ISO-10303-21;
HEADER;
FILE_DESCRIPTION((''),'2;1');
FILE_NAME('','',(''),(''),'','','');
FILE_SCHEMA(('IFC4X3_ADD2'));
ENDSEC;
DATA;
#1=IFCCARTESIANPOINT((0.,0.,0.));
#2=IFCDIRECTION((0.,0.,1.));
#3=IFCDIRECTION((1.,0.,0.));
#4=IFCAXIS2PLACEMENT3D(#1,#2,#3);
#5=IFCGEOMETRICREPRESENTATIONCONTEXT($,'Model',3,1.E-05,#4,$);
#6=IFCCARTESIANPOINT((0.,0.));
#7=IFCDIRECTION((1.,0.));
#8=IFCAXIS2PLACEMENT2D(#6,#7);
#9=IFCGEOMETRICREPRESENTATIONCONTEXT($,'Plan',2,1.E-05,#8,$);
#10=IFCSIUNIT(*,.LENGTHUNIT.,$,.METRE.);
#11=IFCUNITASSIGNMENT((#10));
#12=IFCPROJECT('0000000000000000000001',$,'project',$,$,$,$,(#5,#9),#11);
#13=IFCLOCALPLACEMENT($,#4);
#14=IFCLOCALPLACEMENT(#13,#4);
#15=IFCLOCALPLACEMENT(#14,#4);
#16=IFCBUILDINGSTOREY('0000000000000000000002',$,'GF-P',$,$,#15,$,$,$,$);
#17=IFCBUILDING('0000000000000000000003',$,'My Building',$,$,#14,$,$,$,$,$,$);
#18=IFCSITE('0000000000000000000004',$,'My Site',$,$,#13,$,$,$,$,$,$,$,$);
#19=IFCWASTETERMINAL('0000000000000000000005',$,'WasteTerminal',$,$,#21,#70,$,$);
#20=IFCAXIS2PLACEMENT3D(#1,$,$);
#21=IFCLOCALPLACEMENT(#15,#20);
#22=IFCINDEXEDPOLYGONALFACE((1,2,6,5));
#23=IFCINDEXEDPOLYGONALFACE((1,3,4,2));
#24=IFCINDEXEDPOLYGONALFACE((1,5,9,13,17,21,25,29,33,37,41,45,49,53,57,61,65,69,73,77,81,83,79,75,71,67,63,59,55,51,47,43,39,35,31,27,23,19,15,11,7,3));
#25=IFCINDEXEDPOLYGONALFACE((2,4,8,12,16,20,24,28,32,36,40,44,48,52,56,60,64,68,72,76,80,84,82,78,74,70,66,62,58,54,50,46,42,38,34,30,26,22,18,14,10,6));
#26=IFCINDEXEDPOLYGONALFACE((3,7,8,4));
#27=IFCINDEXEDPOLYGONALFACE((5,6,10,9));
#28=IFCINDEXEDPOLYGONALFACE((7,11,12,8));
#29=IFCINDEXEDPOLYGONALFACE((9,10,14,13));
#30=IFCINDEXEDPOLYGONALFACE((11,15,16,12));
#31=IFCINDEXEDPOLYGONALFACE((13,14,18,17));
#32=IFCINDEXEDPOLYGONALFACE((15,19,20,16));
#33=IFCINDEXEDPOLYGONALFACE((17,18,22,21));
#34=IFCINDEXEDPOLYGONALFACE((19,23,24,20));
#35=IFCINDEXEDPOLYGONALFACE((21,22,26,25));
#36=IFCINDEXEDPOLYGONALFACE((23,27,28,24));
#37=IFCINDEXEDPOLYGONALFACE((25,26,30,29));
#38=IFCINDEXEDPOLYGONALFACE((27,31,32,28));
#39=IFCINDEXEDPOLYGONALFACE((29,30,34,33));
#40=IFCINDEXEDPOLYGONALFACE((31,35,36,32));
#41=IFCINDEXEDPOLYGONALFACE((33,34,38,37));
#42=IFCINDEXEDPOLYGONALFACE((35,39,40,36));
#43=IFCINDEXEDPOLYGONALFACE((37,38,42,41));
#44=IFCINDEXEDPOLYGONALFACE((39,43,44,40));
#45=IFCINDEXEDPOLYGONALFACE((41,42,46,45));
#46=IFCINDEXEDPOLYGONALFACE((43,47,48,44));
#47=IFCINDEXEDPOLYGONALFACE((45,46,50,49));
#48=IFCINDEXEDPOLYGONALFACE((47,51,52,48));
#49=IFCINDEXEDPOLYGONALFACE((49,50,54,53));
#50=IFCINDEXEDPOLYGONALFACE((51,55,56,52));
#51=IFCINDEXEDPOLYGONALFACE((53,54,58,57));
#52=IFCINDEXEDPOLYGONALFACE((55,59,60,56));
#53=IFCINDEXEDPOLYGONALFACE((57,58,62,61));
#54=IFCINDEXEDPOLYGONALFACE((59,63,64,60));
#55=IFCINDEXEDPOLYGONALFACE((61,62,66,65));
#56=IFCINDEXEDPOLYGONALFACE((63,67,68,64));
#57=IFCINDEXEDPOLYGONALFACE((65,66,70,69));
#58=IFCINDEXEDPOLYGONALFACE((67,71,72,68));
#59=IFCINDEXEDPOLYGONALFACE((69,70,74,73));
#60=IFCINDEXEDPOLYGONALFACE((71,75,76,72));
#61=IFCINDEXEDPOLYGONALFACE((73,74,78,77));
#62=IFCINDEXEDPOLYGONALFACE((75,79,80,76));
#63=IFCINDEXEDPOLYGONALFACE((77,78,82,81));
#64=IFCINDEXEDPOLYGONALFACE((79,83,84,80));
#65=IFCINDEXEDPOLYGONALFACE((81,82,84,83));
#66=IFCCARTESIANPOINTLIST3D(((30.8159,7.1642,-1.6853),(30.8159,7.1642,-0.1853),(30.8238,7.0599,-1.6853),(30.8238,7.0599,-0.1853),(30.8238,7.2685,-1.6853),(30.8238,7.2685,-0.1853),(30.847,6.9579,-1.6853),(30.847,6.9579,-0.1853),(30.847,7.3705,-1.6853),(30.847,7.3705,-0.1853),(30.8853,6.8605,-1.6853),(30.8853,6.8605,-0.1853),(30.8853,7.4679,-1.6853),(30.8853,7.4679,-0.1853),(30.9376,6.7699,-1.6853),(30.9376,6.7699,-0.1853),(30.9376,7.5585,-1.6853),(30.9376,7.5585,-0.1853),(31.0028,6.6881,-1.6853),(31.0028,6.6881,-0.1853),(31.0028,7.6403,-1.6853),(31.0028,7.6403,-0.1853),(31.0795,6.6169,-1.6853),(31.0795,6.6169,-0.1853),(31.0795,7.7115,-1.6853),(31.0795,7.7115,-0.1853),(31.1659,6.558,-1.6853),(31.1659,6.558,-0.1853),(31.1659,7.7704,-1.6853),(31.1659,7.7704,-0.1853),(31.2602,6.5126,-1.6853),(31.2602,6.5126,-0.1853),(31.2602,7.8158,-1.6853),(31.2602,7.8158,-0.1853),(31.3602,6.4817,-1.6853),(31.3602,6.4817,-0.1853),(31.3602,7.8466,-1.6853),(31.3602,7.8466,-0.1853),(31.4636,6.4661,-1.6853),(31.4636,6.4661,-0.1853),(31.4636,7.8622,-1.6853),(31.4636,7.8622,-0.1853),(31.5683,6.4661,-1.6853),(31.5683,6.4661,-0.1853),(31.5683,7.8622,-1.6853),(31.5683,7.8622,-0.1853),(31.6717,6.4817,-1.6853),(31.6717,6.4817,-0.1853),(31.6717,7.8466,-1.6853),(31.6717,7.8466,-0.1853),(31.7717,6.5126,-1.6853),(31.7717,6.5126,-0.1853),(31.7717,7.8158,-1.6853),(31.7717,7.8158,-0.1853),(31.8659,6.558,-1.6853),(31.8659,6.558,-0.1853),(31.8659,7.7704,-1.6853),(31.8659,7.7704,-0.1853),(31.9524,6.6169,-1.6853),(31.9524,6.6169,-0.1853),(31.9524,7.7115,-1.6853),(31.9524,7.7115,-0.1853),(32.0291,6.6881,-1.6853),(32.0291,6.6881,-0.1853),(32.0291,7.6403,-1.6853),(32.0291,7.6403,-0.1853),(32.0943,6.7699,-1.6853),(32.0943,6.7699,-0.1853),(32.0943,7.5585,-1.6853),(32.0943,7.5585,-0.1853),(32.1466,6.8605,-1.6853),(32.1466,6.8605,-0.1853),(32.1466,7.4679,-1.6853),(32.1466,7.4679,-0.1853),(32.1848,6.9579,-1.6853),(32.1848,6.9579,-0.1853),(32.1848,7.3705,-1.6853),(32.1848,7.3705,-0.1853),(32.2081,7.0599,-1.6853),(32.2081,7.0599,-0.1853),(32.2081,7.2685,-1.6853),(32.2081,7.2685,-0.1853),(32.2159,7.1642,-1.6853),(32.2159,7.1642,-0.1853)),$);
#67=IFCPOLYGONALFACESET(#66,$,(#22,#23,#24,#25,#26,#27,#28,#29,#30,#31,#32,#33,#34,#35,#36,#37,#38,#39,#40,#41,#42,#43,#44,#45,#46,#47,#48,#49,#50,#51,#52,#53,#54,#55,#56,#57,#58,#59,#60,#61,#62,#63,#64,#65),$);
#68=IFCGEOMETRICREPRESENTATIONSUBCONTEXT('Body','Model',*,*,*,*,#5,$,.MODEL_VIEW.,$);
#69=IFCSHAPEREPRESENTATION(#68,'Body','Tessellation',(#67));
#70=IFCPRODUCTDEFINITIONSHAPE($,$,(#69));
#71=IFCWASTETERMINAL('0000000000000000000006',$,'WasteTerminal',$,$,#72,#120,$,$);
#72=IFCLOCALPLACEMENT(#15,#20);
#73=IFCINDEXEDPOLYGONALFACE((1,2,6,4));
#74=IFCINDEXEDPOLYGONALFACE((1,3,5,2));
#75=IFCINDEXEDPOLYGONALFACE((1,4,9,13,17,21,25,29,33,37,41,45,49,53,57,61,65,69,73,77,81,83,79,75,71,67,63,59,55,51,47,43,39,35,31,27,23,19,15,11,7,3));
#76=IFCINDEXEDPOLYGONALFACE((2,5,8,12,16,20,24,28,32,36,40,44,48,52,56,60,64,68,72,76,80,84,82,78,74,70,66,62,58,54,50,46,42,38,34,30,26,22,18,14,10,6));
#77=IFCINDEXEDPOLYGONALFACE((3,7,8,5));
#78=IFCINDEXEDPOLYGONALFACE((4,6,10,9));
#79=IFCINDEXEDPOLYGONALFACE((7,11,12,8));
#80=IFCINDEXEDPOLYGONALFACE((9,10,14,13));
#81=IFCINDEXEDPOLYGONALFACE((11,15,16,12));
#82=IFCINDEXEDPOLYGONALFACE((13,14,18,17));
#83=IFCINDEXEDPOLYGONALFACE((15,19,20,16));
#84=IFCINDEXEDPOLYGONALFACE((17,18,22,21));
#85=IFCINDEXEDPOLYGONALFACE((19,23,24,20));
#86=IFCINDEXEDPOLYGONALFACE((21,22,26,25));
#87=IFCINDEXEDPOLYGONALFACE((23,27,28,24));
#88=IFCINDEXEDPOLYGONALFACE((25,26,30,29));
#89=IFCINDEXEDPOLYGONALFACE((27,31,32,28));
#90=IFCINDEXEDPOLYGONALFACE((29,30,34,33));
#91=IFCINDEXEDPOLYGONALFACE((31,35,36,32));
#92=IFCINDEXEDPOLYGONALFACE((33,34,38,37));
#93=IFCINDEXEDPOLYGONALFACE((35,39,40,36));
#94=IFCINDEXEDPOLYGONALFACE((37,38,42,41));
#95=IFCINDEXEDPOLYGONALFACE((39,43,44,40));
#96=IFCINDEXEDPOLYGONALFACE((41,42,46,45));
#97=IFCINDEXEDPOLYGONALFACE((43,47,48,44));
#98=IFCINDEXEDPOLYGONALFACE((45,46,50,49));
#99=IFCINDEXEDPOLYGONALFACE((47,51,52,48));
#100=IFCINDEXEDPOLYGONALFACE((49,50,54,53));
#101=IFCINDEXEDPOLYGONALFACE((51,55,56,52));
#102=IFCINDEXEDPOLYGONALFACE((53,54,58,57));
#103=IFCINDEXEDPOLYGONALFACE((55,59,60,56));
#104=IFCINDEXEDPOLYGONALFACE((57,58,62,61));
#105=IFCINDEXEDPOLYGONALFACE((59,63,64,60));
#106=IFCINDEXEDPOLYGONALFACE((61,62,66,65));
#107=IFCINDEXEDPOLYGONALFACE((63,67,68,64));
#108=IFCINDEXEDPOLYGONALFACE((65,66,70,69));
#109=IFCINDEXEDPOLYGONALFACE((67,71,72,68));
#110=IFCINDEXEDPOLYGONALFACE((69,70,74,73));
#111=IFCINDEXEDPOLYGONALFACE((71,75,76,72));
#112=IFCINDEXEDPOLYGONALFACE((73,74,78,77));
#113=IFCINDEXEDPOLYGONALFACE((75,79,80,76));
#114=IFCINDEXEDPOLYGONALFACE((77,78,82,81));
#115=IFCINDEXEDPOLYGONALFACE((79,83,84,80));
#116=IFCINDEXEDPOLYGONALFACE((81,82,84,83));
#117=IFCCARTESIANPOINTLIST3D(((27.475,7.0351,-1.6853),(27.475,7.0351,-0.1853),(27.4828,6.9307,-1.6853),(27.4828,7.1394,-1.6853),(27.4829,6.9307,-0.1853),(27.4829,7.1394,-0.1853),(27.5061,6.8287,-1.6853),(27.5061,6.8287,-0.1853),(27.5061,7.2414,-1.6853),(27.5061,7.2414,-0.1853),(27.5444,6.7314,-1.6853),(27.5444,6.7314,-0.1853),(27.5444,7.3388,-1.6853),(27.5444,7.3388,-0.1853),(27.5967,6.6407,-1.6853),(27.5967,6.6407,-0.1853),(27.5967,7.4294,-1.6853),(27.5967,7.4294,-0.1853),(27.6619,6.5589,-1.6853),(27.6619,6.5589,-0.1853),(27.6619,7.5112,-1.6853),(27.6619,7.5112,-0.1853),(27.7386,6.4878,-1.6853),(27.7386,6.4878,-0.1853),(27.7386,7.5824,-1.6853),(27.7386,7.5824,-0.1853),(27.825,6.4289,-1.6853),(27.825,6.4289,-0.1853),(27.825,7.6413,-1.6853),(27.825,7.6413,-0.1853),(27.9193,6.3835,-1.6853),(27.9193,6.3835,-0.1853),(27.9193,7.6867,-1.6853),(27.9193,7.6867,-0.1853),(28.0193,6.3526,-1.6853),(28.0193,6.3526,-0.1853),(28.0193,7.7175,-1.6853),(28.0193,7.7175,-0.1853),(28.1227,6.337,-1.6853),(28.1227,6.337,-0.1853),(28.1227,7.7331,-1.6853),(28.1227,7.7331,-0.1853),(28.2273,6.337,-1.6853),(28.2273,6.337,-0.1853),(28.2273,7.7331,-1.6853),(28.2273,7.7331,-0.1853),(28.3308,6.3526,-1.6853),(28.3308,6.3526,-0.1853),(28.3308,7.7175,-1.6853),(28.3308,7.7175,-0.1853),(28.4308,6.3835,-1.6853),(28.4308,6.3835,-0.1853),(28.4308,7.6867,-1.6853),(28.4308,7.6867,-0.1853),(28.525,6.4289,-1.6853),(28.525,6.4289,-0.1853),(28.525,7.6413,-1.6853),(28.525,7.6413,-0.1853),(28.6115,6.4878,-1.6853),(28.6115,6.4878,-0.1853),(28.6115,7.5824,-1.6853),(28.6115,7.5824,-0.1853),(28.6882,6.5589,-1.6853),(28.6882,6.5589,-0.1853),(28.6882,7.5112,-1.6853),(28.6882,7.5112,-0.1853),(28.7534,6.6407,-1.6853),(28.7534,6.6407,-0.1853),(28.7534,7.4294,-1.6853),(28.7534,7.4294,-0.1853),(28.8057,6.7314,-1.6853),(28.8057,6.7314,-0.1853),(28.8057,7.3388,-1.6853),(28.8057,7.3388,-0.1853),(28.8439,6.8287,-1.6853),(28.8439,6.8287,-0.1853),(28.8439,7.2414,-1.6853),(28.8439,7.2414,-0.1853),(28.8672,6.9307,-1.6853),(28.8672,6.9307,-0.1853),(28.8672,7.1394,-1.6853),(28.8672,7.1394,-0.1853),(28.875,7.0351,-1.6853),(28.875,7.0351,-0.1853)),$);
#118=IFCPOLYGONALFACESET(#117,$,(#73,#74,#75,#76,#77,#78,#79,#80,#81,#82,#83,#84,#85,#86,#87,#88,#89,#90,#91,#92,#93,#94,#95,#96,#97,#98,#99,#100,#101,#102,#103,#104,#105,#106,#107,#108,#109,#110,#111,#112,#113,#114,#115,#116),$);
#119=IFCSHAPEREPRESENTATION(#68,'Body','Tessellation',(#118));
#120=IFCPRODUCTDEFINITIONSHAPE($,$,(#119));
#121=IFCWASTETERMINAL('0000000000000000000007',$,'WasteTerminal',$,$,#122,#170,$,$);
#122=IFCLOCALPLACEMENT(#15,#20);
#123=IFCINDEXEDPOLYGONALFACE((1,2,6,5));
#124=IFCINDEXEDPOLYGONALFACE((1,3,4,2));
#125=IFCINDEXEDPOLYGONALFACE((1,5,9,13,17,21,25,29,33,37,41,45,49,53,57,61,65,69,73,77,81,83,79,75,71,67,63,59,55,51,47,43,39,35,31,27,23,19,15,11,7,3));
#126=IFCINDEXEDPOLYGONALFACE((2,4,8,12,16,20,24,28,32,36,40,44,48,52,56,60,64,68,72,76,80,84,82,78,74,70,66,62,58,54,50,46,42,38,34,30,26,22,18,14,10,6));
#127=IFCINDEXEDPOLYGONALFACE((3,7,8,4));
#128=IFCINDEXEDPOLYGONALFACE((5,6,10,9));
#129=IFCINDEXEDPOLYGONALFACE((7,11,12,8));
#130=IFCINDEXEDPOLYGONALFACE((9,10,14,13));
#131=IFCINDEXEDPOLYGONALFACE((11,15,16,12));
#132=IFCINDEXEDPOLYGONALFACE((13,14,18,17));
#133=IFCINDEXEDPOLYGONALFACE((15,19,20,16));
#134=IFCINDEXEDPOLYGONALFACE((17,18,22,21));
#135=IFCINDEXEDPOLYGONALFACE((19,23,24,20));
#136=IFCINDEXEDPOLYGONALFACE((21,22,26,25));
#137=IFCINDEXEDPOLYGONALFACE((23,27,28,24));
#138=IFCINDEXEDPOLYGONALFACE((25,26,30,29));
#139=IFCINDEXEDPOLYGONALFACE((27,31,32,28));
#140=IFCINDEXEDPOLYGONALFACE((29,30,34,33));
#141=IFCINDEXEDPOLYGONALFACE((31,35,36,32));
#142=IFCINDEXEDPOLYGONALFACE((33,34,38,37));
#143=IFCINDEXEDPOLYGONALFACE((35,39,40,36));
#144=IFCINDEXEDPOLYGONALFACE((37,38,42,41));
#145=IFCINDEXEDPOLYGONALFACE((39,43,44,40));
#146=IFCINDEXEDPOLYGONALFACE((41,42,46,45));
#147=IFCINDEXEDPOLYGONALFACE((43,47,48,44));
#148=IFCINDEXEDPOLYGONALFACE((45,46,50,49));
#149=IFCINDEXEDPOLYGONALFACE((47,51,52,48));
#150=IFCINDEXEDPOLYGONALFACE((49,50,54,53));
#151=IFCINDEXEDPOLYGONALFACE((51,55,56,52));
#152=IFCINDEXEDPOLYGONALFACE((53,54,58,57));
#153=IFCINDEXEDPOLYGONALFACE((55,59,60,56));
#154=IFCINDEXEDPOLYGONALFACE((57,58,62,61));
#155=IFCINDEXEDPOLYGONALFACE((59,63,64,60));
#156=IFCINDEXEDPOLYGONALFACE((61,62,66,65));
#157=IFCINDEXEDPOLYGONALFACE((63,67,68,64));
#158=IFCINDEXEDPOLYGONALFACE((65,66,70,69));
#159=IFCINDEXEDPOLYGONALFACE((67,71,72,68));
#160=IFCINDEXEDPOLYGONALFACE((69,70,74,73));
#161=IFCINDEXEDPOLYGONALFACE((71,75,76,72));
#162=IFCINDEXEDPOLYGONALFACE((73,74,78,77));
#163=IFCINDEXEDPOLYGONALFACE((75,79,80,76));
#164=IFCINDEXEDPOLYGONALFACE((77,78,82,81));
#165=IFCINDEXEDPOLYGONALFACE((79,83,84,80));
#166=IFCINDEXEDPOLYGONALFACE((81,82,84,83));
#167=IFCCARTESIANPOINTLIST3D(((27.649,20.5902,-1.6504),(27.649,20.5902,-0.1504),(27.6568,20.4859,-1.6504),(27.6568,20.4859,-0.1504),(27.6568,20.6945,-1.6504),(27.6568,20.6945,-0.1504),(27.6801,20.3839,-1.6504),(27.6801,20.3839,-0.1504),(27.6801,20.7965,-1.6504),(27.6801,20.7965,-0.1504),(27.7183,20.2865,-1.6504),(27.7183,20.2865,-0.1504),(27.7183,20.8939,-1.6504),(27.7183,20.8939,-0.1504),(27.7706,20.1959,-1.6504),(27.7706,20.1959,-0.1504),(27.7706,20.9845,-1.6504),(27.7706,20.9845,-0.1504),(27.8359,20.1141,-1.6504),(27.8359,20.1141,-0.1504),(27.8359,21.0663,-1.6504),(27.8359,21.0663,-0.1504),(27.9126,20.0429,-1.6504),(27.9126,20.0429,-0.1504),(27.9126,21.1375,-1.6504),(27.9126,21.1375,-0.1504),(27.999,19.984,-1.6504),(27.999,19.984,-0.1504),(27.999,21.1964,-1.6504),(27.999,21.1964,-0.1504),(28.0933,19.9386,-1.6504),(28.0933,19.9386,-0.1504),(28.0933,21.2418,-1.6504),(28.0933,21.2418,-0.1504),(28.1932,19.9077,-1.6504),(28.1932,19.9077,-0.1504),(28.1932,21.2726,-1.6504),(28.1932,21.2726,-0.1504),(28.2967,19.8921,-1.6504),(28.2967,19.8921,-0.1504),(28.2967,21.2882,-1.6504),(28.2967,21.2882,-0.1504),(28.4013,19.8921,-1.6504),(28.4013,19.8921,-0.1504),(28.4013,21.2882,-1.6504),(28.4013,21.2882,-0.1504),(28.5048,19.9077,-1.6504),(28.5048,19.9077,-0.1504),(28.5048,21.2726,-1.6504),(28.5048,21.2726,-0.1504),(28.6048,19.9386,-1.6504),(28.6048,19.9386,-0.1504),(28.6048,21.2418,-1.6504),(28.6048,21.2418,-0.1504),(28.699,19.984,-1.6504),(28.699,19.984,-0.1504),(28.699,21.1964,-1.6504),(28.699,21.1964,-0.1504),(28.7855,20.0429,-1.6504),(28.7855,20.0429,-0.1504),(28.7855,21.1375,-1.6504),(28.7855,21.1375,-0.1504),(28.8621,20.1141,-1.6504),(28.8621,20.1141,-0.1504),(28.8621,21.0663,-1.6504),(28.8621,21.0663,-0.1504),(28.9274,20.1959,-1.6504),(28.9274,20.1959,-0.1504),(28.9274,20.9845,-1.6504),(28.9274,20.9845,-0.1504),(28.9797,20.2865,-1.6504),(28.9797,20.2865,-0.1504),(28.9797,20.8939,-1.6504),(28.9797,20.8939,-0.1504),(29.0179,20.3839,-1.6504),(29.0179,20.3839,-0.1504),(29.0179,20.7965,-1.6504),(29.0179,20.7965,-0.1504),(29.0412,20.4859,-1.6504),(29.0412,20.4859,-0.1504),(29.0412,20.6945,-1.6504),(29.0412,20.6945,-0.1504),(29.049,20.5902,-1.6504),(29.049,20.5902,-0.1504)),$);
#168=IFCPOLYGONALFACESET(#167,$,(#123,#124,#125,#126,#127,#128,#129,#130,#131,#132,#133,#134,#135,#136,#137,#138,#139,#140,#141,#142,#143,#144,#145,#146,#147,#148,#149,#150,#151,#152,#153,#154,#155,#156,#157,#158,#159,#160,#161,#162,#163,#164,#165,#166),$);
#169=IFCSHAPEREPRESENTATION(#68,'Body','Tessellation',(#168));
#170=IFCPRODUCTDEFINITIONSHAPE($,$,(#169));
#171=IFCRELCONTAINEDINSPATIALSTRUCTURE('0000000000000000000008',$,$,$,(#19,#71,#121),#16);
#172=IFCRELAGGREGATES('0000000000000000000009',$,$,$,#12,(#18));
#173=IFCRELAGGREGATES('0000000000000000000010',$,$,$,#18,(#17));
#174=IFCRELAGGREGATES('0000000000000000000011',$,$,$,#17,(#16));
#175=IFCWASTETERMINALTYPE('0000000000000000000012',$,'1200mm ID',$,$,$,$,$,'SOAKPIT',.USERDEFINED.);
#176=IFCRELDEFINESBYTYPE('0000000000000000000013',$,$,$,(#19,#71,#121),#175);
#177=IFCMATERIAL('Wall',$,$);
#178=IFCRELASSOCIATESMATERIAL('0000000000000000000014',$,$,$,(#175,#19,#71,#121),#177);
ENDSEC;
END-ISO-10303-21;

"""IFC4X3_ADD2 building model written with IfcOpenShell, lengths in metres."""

from ifc_helpers import new_model, si_unit, frame, origin_with_axes, origin_2d_with_axis, place, context, subcontext, project, spatial, circle, extrude, material, material_profile, profile_set, profile_usage, type_object, element, save


model = new_model("IFC4X3_ADD2")

# Units and contexts
model_context = context("Model", 3, precision=1e-05, world=origin_with_axes())
plan_context = context("Plan", 2, precision=1e-05, world=origin_2d_with_axis())
body_context = subcontext(model_context, "Body", "Model", "MODEL_VIEW")
ifc_project = project(units=[si_unit("LENGTHUNIT", "METRE")], contexts=[model_context, plan_context])

# Site, building, storey
site_placement = place(None, origin_with_axes())
site = spatial("IfcSite", under=ifc_project, at=site_placement, Name="My Site")
building_placement = place(site_placement, origin_with_axes())
building = spatial("IfcBuilding", under=site, at=building_placement, Name="My Building")
storey_placement = place(building_placement, origin_with_axes())
storey = spatial("IfcBuildingStorey", under=building, at=storey_placement, Name="GF-P")

# Shared definitions
ifc_material_1 = material(Name="Wall")

# Waste terminals
ifc_material_profile_1 = material_profile(ifc_material_1, circle(Radius=0.7))
ifc_profile_set_1 = profile_set([ifc_material_profile_1])
ifc_profile_usage_1 = profile_usage(ifc_profile_set_1, cardinal=5)
waste_terminal_type = type_object("IfcWasteTerminalType", Name="1200mm ID", ElementType="SOAKPIT", PredefinedType="USERDEFINED", material=ifc_profile_set_1)
waste_terminal_1_placement = place(storey_placement, frame((31.5159, 7.1642, -0.1853), z_axis=(0.0, 0.0, -1.0), x_axis=(-1.0, 0.0, 0.0)))
element("IfcWasteTerminal", 1, at=waste_terminal_1_placement, inside=storey, type_object=waste_terminal_type, material=ifc_profile_usage_1, Name="WasteTerminal", context=body_context, shape_type="SweptSolid", body=[
    extrude(circle(Radius=0.7), origin_with_axes(), (0.0, 0.0, 1.0), 1.5),
])
ifc_profile_usage_2 = profile_usage(ifc_profile_set_1, cardinal=5)
waste_terminal_2_placement = place(storey_placement, frame((28.175, 7.0351, -0.1853), z_axis=(0.0, 0.0, -1.0), x_axis=(-1.0, 0.0, 0.0)))
element("IfcWasteTerminal", 2, at=waste_terminal_2_placement, inside=storey, type_object=waste_terminal_type, material=ifc_profile_usage_2, Name="WasteTerminal", context=body_context, shape_type="SweptSolid", body=[
    extrude(circle(Radius=0.7), origin_with_axes(), (0.0, 0.0, 1.0), 1.5),
])
ifc_profile_usage_3 = profile_usage(ifc_profile_set_1, cardinal=5)
waste_terminal_3_placement = place(storey_placement, frame((28.349, 20.5902, -0.1504), z_axis=(0.0, 0.0, -1.0), x_axis=(-1.0, 0.0, 0.0)))
element("IfcWasteTerminal", 3, at=waste_terminal_3_placement, inside=storey, type_object=waste_terminal_type, material=ifc_profile_usage_3, Name="WasteTerminal", context=body_context, shape_type="SweptSolid", body=[
    extrude(circle(Radius=0.7), origin_with_axes(), (0.0, 0.0, 1.0), 1.5),
])

save(model, "model.ifc")
